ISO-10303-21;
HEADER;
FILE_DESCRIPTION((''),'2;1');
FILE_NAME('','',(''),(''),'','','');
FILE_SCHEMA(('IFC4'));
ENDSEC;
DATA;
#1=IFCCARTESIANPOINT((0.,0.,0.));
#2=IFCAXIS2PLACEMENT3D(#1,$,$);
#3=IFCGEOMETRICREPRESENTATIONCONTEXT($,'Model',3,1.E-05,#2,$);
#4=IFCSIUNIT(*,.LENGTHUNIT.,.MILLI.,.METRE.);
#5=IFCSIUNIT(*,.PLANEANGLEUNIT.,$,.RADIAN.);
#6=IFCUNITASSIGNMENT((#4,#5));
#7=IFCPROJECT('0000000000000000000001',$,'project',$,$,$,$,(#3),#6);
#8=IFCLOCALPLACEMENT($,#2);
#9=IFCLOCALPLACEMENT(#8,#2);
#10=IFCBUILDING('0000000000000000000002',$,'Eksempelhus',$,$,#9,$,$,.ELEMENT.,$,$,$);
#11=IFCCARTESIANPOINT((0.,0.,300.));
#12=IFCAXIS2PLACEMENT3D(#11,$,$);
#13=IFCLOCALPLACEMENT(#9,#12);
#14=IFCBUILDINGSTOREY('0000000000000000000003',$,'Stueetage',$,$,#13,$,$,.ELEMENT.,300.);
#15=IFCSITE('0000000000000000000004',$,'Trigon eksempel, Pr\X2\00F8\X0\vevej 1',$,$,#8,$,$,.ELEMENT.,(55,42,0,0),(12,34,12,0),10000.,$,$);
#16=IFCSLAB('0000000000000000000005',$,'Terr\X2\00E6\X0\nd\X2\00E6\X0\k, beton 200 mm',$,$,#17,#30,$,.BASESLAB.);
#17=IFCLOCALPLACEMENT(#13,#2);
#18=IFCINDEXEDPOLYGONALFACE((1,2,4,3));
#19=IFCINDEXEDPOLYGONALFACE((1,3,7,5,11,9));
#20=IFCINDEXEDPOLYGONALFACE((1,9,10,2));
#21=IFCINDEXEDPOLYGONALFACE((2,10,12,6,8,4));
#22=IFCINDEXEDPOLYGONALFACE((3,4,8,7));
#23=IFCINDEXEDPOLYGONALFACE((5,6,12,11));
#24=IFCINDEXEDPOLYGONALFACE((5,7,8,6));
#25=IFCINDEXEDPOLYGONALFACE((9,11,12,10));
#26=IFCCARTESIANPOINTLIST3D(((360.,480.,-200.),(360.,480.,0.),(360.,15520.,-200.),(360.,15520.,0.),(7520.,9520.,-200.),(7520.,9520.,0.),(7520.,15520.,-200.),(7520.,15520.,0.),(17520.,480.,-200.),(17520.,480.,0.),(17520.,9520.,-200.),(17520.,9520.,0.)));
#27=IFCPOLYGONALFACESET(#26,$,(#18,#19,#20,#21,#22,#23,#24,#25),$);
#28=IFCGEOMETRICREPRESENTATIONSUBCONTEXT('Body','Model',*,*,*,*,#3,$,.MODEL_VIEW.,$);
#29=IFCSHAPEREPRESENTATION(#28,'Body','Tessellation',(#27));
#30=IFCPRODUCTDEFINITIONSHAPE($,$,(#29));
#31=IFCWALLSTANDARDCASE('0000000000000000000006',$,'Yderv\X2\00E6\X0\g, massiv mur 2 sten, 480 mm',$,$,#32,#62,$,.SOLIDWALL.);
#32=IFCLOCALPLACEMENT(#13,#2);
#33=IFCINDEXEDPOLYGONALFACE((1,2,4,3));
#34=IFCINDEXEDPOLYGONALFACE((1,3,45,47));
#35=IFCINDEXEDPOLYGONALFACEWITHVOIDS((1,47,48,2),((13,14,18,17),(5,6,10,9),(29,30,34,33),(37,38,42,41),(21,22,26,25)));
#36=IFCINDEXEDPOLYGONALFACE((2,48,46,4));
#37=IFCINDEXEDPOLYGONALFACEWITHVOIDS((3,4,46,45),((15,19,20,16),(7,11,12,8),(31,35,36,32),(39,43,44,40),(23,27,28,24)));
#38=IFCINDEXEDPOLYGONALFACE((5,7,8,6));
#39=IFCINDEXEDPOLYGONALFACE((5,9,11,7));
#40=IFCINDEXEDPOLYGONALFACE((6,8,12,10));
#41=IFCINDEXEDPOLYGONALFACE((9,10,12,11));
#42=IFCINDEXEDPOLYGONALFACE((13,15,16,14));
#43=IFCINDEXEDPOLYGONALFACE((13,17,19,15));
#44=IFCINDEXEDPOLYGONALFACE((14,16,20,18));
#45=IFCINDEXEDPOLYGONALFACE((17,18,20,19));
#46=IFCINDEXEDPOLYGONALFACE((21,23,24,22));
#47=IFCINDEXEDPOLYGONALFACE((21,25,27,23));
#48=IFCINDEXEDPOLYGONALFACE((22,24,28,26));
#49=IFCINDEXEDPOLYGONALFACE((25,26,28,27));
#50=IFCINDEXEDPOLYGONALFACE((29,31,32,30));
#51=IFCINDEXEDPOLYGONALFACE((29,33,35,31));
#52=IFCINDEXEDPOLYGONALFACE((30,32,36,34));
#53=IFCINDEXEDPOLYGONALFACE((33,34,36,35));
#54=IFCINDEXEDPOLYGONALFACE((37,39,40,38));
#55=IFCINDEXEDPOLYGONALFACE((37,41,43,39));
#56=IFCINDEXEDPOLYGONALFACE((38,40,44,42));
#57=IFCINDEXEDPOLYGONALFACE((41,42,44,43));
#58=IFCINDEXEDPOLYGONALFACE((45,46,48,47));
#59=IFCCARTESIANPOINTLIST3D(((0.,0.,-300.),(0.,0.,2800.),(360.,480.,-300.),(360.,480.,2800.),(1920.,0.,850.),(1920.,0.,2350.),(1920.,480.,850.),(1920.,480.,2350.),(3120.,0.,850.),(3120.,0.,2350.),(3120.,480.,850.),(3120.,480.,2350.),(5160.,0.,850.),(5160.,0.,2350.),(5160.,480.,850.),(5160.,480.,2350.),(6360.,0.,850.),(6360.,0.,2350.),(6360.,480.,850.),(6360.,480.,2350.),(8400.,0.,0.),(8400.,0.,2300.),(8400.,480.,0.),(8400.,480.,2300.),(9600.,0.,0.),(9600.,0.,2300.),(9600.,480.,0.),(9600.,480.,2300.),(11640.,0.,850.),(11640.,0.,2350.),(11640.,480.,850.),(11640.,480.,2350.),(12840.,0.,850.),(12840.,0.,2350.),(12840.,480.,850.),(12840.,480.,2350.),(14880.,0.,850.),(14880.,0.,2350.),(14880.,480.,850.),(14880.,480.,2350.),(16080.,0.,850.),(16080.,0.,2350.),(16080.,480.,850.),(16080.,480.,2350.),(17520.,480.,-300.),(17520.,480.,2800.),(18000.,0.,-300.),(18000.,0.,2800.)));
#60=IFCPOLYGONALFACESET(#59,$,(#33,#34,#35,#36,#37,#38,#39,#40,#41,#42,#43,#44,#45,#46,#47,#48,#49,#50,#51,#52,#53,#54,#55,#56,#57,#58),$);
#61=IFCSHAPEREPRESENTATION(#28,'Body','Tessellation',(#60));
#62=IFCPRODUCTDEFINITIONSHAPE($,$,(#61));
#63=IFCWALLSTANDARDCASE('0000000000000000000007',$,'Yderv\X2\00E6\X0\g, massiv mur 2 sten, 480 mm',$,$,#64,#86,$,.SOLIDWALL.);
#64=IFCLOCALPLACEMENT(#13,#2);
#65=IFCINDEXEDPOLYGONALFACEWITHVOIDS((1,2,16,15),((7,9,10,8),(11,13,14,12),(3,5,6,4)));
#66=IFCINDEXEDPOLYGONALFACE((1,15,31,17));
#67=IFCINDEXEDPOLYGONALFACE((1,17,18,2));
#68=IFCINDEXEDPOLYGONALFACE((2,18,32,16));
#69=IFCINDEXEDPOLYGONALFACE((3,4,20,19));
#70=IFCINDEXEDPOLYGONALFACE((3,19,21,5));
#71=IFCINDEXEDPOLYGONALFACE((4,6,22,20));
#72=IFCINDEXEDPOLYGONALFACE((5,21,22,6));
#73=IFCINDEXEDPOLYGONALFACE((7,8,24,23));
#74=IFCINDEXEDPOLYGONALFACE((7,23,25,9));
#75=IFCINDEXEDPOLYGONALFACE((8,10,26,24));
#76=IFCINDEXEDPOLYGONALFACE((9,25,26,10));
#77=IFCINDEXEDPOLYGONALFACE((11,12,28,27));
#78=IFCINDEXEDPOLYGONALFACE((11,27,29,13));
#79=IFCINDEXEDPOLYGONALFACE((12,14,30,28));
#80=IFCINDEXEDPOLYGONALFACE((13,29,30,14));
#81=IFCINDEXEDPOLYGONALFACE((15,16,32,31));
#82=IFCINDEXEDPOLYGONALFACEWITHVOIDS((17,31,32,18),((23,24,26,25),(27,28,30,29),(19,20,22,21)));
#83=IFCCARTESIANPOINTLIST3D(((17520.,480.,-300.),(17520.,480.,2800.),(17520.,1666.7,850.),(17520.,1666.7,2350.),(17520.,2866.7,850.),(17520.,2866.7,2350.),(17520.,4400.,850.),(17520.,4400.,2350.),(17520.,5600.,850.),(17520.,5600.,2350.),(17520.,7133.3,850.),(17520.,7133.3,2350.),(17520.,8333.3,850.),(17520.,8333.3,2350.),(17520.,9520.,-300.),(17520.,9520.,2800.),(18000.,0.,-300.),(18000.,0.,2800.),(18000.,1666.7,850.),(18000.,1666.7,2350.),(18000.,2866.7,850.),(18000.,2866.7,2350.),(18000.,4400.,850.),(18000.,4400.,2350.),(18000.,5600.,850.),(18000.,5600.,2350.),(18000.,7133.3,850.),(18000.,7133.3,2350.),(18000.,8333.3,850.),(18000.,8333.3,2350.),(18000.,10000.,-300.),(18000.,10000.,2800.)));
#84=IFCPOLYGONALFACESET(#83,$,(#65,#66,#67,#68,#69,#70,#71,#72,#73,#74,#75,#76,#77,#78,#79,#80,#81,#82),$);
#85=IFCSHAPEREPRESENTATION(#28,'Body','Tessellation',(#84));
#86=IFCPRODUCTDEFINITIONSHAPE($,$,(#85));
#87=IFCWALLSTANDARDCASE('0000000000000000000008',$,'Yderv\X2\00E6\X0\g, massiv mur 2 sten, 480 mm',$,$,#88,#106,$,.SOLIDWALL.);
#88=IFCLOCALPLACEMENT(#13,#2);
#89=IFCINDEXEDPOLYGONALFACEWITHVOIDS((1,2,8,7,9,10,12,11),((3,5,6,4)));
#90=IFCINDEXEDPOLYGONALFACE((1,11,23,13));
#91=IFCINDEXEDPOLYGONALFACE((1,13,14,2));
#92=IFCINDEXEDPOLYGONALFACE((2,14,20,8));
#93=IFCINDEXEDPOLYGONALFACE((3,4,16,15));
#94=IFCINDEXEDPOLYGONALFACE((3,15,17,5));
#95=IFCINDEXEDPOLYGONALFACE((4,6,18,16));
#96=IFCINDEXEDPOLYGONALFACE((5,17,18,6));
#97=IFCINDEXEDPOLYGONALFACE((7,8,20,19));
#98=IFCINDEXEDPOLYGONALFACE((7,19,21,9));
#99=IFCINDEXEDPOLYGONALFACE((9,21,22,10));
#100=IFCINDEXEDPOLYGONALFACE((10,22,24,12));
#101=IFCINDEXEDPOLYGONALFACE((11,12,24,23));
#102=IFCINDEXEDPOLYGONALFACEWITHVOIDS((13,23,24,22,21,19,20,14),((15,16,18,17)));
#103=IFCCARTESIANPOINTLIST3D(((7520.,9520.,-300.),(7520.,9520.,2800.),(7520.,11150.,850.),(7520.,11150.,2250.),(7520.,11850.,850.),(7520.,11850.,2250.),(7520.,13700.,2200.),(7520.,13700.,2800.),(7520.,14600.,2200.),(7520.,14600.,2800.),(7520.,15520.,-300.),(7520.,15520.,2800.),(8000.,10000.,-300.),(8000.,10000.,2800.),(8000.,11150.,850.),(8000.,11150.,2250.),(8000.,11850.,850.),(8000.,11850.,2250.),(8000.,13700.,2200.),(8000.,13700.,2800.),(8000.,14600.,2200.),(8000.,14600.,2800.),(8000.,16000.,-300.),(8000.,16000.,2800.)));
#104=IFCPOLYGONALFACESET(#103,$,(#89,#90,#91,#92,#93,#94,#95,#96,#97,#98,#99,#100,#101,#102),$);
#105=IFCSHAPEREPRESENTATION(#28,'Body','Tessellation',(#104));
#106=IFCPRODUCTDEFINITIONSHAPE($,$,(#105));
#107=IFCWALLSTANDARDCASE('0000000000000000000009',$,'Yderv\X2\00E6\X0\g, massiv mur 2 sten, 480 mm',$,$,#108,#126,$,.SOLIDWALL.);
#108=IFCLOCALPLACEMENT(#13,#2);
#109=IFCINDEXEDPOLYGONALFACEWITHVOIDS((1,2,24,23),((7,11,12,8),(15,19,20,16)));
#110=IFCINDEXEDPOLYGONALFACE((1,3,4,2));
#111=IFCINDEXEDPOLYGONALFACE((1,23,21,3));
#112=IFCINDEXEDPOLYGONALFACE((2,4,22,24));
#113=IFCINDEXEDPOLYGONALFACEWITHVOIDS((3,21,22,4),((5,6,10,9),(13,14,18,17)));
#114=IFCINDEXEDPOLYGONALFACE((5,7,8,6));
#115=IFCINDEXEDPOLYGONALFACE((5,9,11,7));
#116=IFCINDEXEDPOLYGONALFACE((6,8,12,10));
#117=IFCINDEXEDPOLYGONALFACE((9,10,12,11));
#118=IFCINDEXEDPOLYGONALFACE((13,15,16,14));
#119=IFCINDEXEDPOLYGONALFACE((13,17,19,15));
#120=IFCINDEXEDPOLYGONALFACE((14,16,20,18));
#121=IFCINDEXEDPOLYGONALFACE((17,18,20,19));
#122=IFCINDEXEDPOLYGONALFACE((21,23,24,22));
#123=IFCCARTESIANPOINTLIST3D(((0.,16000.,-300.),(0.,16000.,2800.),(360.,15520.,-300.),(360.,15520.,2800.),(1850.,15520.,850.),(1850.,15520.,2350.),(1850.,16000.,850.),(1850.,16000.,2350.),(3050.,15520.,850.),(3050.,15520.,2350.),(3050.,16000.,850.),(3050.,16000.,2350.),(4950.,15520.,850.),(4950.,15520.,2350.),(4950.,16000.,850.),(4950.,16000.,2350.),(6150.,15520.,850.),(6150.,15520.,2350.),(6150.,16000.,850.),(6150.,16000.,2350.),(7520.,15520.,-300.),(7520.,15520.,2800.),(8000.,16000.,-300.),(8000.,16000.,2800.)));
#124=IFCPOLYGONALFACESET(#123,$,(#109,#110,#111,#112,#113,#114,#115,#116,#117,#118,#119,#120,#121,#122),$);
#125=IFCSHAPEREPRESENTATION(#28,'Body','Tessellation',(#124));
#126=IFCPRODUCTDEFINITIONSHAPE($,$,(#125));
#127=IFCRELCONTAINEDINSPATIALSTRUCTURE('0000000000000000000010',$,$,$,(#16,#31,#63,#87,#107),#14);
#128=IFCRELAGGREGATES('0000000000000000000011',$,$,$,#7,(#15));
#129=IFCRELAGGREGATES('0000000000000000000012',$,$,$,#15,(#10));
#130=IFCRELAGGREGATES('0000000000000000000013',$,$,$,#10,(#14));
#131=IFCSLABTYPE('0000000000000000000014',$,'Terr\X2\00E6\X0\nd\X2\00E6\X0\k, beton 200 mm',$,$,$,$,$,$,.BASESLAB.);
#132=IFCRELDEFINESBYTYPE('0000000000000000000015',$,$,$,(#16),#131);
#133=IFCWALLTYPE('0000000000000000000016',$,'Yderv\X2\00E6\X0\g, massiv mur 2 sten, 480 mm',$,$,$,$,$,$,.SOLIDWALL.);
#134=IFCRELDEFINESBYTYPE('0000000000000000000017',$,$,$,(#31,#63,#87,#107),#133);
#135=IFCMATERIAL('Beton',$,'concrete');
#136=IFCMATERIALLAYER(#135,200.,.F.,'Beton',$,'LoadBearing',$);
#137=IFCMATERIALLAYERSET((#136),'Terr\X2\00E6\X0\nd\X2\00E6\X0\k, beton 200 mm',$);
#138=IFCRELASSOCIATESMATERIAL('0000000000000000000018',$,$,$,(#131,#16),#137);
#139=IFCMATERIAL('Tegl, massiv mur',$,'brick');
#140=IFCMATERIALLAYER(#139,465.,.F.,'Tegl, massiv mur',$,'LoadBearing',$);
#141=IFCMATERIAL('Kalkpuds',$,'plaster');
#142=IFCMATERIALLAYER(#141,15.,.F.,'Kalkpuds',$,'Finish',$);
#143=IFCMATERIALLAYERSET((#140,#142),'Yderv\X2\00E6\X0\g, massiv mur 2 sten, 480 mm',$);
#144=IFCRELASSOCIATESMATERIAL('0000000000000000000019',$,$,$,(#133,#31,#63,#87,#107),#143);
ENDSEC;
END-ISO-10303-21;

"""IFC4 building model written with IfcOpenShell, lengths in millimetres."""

from ifc_helpers import new_model, si_unit, frame, origin, place, context, subcontext, project, spatial, polyline, rectangle, outline, extrude, material, layer, layer_set, layer_usage, type_object, element, save


model = new_model("IFC4")

# Units and contexts
model_context = context("Model", 3, precision=1e-05, world=origin())
body_context = subcontext(model_context, "Body", "Model", "MODEL_VIEW")
ifc_project = project(units=[si_unit("LENGTHUNIT", "METRE", prefix="MILLI"), si_unit("PLANEANGLEUNIT", "RADIAN")], contexts=[model_context])

# Site, building, storey
site_placement = place(None, origin())
site = spatial("IfcSite", under=ifc_project, at=site_placement, Name="Trigon eksempel, Prøvevej 1", CompositionType="ELEMENT", RefLatitude=(55, 42, 0, 0), RefLongitude=(12, 34, 12, 0), RefElevation=10000.0)
building_placement = place(site_placement, origin())
building = spatial("IfcBuilding", under=site, at=building_placement, Name="Eksempelhus", CompositionType="ELEMENT")
storey_placement = place(building_placement, frame((0.0, 0.0, 300.0)))
storey = spatial("IfcBuildingStorey", under=building, at=storey_placement, Name="Stueetage", CompositionType="ELEMENT", Elevation=300.0)

# Slab
ifc_material_1 = material(Name="Beton", Category="concrete")
ifc_layer_1 = layer(ifc_material_1, 200.0, ventilated=False, Name="Beton", Category="LoadBearing")
ifc_layer_set_1 = layer_set([ifc_layer_1], Name="Terrændæk, beton 200 mm")
ifc_layer_usage_1 = layer_usage(ifc_layer_set_1, "AXIS3", "POSITIVE", 0.0)
slab_type = type_object("IfcSlabType", Name="Terrændæk, beton 200 mm", PredefinedType="BASESLAB", material=ifc_layer_set_1)
slab_placement = place(storey_placement, frame((0.0, 0.0, -200.0)))
element("IfcSlab", 1, at=slab_placement, inside=storey, type_object=slab_type, material=ifc_layer_usage_1, Name="Terrændæk, beton 200 mm", PredefinedType="BASESLAB", context=body_context, shape_type="SweptSolid", body=[
    extrude(outline(polyline([(360.0, 480.0), (17520.0, 480.0), (17520.0, 9520.0), (7520.0, 9520.0), (7520.0, 15520.0), (360.0, 15520.0), (360.0, 480.0)])), origin(), (0.0, 0.0, 1.0), 200.0),
])

# Walls, openings
ifc_material_2 = material(Name="Tegl, massiv mur", Category="brick")
ifc_layer_2 = layer(ifc_material_2, 465.0, ventilated=False, Name="Tegl, massiv mur", Category="LoadBearing")
ifc_material_3 = material(Name="Kalkpuds", Category="plaster")
ifc_layer_3 = layer(ifc_material_3, 15.0, ventilated=False, Name="Kalkpuds", Category="Finish")
ifc_layer_set_2 = layer_set([ifc_layer_2, ifc_layer_3], Name="Ydervæg, massiv mur 2 sten, 480 mm")
ifc_layer_usage_2 = layer_usage(ifc_layer_set_2, "AXIS2", "POSITIVE", 0.0)
wall_type_1 = type_object("IfcWallType", Name="Ydervæg, massiv mur 2 sten, 480 mm", PredefinedType="SOLIDWALL", material=ifc_layer_set_2)
wall_1_placement = place(storey_placement, frame((0.0, 0.0, -300.0)))
wall_1 = element("IfcWallStandardCase", 2, at=wall_1_placement, inside=storey, type_object=wall_type_1, material=ifc_layer_usage_2, Name="Ydervæg, massiv mur 2 sten, 480 mm", PredefinedType="SOLIDWALL", context=body_context, shape_type="SweptSolid", body=[
    extrude(outline(polyline([(0.0, 0.0), (18000.0, 0.0), (17520.0, 480.0), (360.0, 480.0), (0.0, 0.0)])), origin(), (0.0, 0.0, 1.0), 3100.0),
])
opening_1_placement = place(wall_1_placement, frame((1920.0, 0.0, 1150.0)))
element("IfcOpeningElement", 3, at=opening_1_placement, cuts=wall_1, PredefinedType="OPENING", context=body_context, shape_type="SweptSolid", body=[
    extrude(rectangle(XDim=1200.0, YDim=1500.0), frame((600.0, 0.0, 750.0), z_axis=(0.0, 1.0, 0.0), x_axis=(1.0, 0.0, 0.0)), (0.0, 0.0, 1.0), 480.0),
])
opening_2_placement = place(wall_1_placement, frame((5160.0, 0.0, 1150.0)))
element("IfcOpeningElement", 4, at=opening_2_placement, cuts=wall_1, PredefinedType="OPENING", context=body_context, shape_type="SweptSolid", body=[
    extrude(rectangle(XDim=1200.0, YDim=1500.0), frame((600.0, 0.0, 750.0), z_axis=(0.0, 1.0, 0.0), x_axis=(1.0, 0.0, 0.0)), (0.0, 0.0, 1.0), 480.0),
])
opening_3_placement = place(wall_1_placement, frame((8400.0, 0.0, 300.0)))
element("IfcOpeningElement", 5, at=opening_3_placement, cuts=wall_1, PredefinedType="OPENING", context=body_context, shape_type="SweptSolid", body=[
    extrude(rectangle(XDim=1200.0, YDim=2300.0), frame((600.0, 0.0, 1150.0), z_axis=(0.0, 1.0, 0.0), x_axis=(1.0, 0.0, 0.0)), (0.0, 0.0, 1.0), 480.0),
])
opening_4_placement = place(wall_1_placement, frame((11640.0, 0.0, 1150.0)))
element("IfcOpeningElement", 6, at=opening_4_placement, cuts=wall_1, PredefinedType="OPENING", context=body_context, shape_type="SweptSolid", body=[
    extrude(rectangle(XDim=1200.0, YDim=1500.0), frame((600.0, 0.0, 750.0), z_axis=(0.0, 1.0, 0.0), x_axis=(1.0, 0.0, 0.0)), (0.0, 0.0, 1.0), 480.0),
])
opening_5_placement = place(wall_1_placement, frame((14880.0, 0.0, 1150.0)))
element("IfcOpeningElement", 7, at=opening_5_placement, cuts=wall_1, PredefinedType="OPENING", context=body_context, shape_type="SweptSolid", body=[
    extrude(rectangle(XDim=1200.0, YDim=1500.0), frame((600.0, 0.0, 750.0), z_axis=(0.0, 1.0, 0.0), x_axis=(1.0, 0.0, 0.0)), (0.0, 0.0, 1.0), 480.0),
])
wall_2_placement = place(storey_placement, frame((18000.0, 0.0, -300.0), z_axis=(0.0, 0.0, 1.0), x_axis=(0.0, 1.0, 0.0)))
wall_2 = element("IfcWallStandardCase", 8, at=wall_2_placement, inside=storey, type_object=wall_type_1, material=ifc_layer_usage_2, Name="Ydervæg, massiv mur 2 sten, 480 mm", PredefinedType="SOLIDWALL", context=body_context, shape_type="SweptSolid", body=[
    extrude(outline(polyline([(0.0, 0.0), (10000.0, 0.0), (9520.0, 480.0), (480.0, 480.0), (0.0, 0.0)])), origin(), (0.0, 0.0, 1.0), 3100.0),
])
opening_6_placement = place(wall_2_placement, frame((1666.7, 0.0, 1150.0)))
element("IfcOpeningElement", 9, at=opening_6_placement, cuts=wall_2, PredefinedType="OPENING", context=body_context, shape_type="SweptSolid", body=[
    extrude(rectangle(XDim=1200.0, YDim=1500.0), frame((600.0, 0.0, 750.0), z_axis=(0.0, 1.0, 0.0), x_axis=(1.0, 0.0, 0.0)), (0.0, 0.0, 1.0), 480.0),
])
opening_7_placement = place(wall_2_placement, frame((4400.0, 0.0, 1150.0)))
element("IfcOpeningElement", 10, at=opening_7_placement, cuts=wall_2, PredefinedType="OPENING", context=body_context, shape_type="SweptSolid", body=[
    extrude(rectangle(XDim=1200.0, YDim=1500.0), frame((600.0, 0.0, 750.0), z_axis=(0.0, 1.0, 0.0), x_axis=(1.0, 0.0, 0.0)), (0.0, 0.0, 1.0), 480.0),
])
opening_8_placement = place(wall_2_placement, frame((7133.3, 0.0, 1150.0)))
element("IfcOpeningElement", 11, at=opening_8_placement, cuts=wall_2, PredefinedType="OPENING", context=body_context, shape_type="SweptSolid", body=[
    extrude(rectangle(XDim=1200.0, YDim=1500.0), frame((600.0, 0.0, 750.0), z_axis=(0.0, 1.0, 0.0), x_axis=(1.0, 0.0, 0.0)), (0.0, 0.0, 1.0), 480.0),
])
wall_3_placement = place(storey_placement, frame((8000.0, 10000.0, -300.0), z_axis=(0.0, 0.0, 1.0), x_axis=(0.0, 1.0, 0.0)))
wall_3 = element("IfcWallStandardCase", 12, at=wall_3_placement, inside=storey, type_object=wall_type_1, material=ifc_layer_usage_2, Name="Ydervæg, massiv mur 2 sten, 480 mm", PredefinedType="SOLIDWALL", context=body_context, shape_type="SweptSolid", body=[
    extrude(outline(polyline([(0.0, 0.0), (6000.0, 0.0), (5520.0, 480.0), (-480.0, 480.0), (0.0, 0.0)])), origin(), (0.0, 0.0, 1.0), 3100.0),
])
opening_9_placement = place(wall_3_placement, frame((1150.0, 0.0, 1150.0)))
element("IfcOpeningElement", 13, at=opening_9_placement, cuts=wall_3, PredefinedType="OPENING", context=body_context, shape_type="SweptSolid", body=[
    extrude(rectangle(XDim=700.0, YDim=1400.0), frame((350.0, 0.0, 700.0), z_axis=(0.0, 1.0, 0.0), x_axis=(1.0, 0.0, 0.0)), (0.0, 0.0, 1.0), 480.0),
])
opening_10_placement = place(wall_3_placement, frame((3700.0, 0.0, 2500.0)))
element("IfcOpeningElement", 14, at=opening_10_placement, cuts=wall_3, PredefinedType="OPENING", context=body_context, shape_type="SweptSolid", body=[
    extrude(rectangle(XDim=900.0, YDim=600.0), frame((450.0, 0.0, 300.0), z_axis=(0.0, 1.0, 0.0), x_axis=(1.0, 0.0, 0.0)), (0.0, 0.0, 1.0), 480.0),
])
wall_4_placement = place(storey_placement, frame((8000.0, 16000.0, -300.0), z_axis=(0.0, 0.0, 1.0), x_axis=(-1.0, 0.0, 0.0)))
wall_4 = element("IfcWallStandardCase", 15, at=wall_4_placement, inside=storey, type_object=wall_type_1, material=ifc_layer_usage_2, Name="Ydervæg, massiv mur 2 sten, 480 mm", PredefinedType="SOLIDWALL", context=body_context, shape_type="SweptSolid", body=[
    extrude(outline(polyline([(0.0, 0.0), (8000.0, 0.0), (7640.0, 480.0), (480.0, 480.0), (0.0, 0.0)])), origin(), (0.0, 0.0, 1.0), 3100.0),
])
opening_11_placement = place(wall_4_placement, frame((1850.0, 0.0, 1150.0)))
element("IfcOpeningElement", 16, at=opening_11_placement, cuts=wall_4, PredefinedType="OPENING", context=body_context, shape_type="SweptSolid", body=[
    extrude(rectangle(XDim=1200.0, YDim=1500.0), frame((600.0, 0.0, 750.0), z_axis=(0.0, 1.0, 0.0), x_axis=(1.0, 0.0, 0.0)), (0.0, 0.0, 1.0), 480.0),
])
opening_12_placement = place(wall_4_placement, frame((4950.0, 0.0, 1150.0)))
element("IfcOpeningElement", 17, at=opening_12_placement, cuts=wall_4, PredefinedType="OPENING", context=body_context, shape_type="SweptSolid", body=[
    extrude(rectangle(XDim=1200.0, YDim=1500.0), frame((600.0, 0.0, 750.0), z_axis=(0.0, 1.0, 0.0), x_axis=(1.0, 0.0, 0.0)), (0.0, 0.0, 1.0), 480.0),
])

save(model, "model.ifc")
